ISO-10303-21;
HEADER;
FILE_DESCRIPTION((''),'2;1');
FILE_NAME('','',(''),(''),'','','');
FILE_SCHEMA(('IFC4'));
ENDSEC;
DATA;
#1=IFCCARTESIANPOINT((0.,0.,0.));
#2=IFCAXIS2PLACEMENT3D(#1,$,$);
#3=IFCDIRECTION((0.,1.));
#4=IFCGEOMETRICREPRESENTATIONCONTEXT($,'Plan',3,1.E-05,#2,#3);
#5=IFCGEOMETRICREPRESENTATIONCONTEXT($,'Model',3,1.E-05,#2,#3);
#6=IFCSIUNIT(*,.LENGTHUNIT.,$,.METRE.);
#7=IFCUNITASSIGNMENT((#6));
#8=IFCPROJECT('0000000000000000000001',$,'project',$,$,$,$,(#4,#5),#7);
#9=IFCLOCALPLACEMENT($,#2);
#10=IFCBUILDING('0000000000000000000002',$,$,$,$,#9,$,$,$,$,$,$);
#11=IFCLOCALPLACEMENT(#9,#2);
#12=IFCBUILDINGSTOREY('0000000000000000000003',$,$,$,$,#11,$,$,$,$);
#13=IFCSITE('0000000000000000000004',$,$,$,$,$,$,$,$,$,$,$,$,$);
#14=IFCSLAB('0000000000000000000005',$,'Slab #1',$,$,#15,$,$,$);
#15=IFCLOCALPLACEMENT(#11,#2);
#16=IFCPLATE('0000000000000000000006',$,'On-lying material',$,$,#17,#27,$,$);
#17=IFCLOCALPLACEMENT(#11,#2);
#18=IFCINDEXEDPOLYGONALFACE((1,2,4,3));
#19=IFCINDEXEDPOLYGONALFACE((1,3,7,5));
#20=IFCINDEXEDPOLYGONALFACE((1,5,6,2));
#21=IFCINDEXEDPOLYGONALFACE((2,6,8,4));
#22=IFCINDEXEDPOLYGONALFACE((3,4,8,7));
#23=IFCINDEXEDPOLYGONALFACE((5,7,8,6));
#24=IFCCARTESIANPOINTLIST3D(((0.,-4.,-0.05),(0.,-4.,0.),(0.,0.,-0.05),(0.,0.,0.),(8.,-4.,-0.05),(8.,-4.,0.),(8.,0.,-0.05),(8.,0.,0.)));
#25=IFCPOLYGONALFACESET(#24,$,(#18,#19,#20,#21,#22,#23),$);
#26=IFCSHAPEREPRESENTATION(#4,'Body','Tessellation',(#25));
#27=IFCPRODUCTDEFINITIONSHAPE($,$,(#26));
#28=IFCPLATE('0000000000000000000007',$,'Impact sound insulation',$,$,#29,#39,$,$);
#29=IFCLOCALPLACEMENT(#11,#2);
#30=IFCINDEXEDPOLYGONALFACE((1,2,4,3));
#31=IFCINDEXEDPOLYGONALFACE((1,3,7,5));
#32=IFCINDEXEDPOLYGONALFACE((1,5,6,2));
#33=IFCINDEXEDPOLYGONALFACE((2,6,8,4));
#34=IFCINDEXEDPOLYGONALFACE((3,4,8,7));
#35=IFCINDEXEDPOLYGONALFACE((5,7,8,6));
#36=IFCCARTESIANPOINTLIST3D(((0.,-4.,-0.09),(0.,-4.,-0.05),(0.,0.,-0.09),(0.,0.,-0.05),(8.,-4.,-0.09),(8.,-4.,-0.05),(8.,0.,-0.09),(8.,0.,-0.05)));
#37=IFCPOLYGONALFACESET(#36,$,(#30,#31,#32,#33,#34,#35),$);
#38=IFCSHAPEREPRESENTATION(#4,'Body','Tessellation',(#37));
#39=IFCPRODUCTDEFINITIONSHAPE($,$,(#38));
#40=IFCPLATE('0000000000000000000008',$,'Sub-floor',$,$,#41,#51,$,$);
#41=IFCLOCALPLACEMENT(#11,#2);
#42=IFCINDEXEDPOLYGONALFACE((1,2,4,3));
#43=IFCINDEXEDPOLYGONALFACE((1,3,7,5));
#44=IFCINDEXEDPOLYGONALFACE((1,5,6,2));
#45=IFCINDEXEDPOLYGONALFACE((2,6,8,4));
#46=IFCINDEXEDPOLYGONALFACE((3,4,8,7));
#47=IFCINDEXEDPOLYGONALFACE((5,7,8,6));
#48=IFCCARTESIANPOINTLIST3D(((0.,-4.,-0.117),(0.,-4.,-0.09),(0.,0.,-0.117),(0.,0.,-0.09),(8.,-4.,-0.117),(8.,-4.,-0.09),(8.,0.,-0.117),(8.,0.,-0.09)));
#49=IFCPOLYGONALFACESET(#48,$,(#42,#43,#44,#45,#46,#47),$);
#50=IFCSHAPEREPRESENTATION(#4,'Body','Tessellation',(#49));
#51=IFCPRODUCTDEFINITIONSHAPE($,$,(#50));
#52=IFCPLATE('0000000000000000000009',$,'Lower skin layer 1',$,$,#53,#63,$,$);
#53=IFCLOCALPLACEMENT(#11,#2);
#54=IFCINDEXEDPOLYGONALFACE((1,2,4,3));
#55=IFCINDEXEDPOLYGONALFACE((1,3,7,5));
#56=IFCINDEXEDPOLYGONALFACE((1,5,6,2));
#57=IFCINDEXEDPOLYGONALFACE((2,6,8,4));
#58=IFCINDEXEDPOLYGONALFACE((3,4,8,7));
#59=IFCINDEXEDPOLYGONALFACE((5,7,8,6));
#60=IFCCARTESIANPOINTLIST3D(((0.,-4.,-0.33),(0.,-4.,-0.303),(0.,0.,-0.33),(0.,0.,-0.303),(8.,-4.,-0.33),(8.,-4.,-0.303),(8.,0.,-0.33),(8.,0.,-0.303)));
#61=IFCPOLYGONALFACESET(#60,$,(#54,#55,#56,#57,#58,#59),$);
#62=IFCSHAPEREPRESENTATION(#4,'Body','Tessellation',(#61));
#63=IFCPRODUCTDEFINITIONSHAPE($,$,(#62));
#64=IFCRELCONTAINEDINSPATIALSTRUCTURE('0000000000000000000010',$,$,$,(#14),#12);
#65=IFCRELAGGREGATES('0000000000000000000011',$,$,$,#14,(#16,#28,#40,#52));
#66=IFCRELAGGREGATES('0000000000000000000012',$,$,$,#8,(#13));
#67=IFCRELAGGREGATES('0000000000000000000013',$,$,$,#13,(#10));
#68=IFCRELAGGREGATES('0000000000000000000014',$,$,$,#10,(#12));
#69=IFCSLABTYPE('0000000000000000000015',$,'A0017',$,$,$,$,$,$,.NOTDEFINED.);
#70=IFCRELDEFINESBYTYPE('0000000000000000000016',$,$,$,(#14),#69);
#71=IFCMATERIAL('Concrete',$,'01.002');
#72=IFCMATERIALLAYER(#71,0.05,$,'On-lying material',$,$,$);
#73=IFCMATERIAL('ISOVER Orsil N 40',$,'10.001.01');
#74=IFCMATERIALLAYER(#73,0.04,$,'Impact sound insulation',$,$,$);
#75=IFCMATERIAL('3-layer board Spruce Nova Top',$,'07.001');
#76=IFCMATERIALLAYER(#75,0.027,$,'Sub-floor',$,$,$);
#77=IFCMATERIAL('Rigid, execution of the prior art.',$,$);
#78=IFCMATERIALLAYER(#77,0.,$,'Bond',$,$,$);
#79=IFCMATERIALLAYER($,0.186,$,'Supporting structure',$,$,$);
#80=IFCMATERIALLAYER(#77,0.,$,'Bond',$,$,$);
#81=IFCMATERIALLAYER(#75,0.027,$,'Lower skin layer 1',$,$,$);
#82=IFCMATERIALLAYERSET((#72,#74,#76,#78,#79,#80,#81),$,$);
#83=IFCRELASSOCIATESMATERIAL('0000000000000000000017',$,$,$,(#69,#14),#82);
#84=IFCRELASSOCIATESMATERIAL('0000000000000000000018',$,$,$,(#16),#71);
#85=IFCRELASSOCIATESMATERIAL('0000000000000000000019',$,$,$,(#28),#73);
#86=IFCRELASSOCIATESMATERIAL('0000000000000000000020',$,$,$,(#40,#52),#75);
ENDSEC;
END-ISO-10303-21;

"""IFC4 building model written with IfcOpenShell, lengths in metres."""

from ifc_helpers import new_model, si_unit, direction, frame, frame_2d, origin, origin_with_axes, place, context, project, spatial, rectangle, extrude, material, layer, layer_set, type_object, element, aggregate, save


model = new_model("IFC4")

# Units and contexts
plan_context = context("Plan", 3, precision=1e-05, world=origin(), true_north=direction((0.0, 1.0)))
model_context = context("Model", 3, precision=1e-05, world=origin(), true_north=direction((0.0, 1.0)))
ifc_project = project(units=[si_unit("LENGTHUNIT", "METRE")], contexts=[plan_context, model_context])

# Site, building, storey
site = spatial("IfcSite", under=ifc_project)
building_placement = place(None, origin())
building = spatial("IfcBuilding", under=site, at=building_placement)
storey_placement = place(building_placement, origin())
storey = spatial("IfcBuildingStorey", under=building, at=storey_placement)

# Slab, plates
ifc_material_1 = material(Name="Concrete", Category="01.002")
ifc_layer_1 = layer(ifc_material_1, 0.05, Name="On-lying material")
ifc_material_2 = material(Name="ISOVER Orsil N 40", Category="10.001.01")
ifc_layer_2 = layer(ifc_material_2, 0.04, Name="Impact sound insulation")
ifc_material_3 = material(Name="3-layer board Spruce Nova Top", Category="07.001")
ifc_layer_3 = layer(ifc_material_3, 0.027, Name="Sub-floor")
ifc_material_4 = material(Name="Rigid, execution of the prior art.")
ifc_layer_4 = layer(ifc_material_4, 0.0, Name="Bond")
ifc_layer_5 = layer(None, 0.186, Name="Supporting structure")
ifc_layer_6 = layer(ifc_material_4, 0.0, Name="Bond")
ifc_layer_7 = layer(ifc_material_3, 0.027, Name="Lower skin layer 1")
ifc_layer_set = layer_set([ifc_layer_1, ifc_layer_2, ifc_layer_3, ifc_layer_4, ifc_layer_5, ifc_layer_6, ifc_layer_7])
slab_type = type_object("IfcSlabType", Name="A0017", PredefinedType="NOTDEFINED", material=ifc_layer_set)
slab_placement = place(None, frame((0.0, 0.0, 0.0), z_axis=(0.0, 0.0, -1.0), x_axis=(1.0, 0.0, 0.0)))
slab = element("IfcSlab", 1, at=slab_placement, inside=storey, type_object=slab_type, material=ifc_layer_set, Name="Slab #1")
plate_1_placement = place(slab_placement, origin())
plate_1 = element("IfcPlate", 2, at=plate_1_placement, material=ifc_material_1, Name="On-lying material", context=plan_context, shape_type="SweptSolid", body=[
    extrude(rectangle(XDim=8.0, YDim=4.0, at=frame_2d((4.0, 2.0), x_axis=(1.0, 0.0))), origin_with_axes(), (0.0, 0.0, 1.0), 0.05),
])
plate_2_placement = place(slab_placement, origin())
plate_2 = element("IfcPlate", 3, at=plate_2_placement, material=ifc_material_2, Name="Impact sound insulation", context=plan_context, shape_type="SweptSolid", body=[
    extrude(rectangle(XDim=8.0, YDim=4.0, at=frame_2d((4.0, 2.0), x_axis=(1.0, 0.0))), frame((0.0, 0.0, 0.05), z_axis=(0.0, 0.0, 1.0), x_axis=(1.0, 0.0, 0.0)), (0.0, 0.0, 1.0), 0.04),
])
plate_3_placement = place(slab_placement, origin())
plate_3 = element("IfcPlate", 4, at=plate_3_placement, material=ifc_material_3, Name="Sub-floor", context=plan_context, shape_type="SweptSolid", body=[
    extrude(rectangle(XDim=8.0, YDim=4.0, at=frame_2d((4.0, 2.0), x_axis=(1.0, 0.0))), frame((0.0, 0.0, 0.09), z_axis=(0.0, 0.0, 1.0), x_axis=(1.0, 0.0, 0.0)), (0.0, 0.0, 1.0), 0.027),
])
plate_4_placement = place(slab_placement, origin())
plate_4 = element("IfcPlate", 5, at=plate_4_placement, material=ifc_material_3, Name="Lower skin layer 1", context=plan_context, shape_type="SweptSolid", body=[
    extrude(rectangle(XDim=8.0, YDim=4.0, at=frame_2d((4.0, 2.0), x_axis=(1.0, 0.0))), frame((0.0, 0.0, 0.303), z_axis=(0.0, 0.0, 1.0), x_axis=(1.0, 0.0, 0.0)), (0.0, 0.0, 1.0), 0.027),
])
aggregate(slab, [plate_1, plate_2, plate_3, plate_4])

save(model, "model.ifc")
